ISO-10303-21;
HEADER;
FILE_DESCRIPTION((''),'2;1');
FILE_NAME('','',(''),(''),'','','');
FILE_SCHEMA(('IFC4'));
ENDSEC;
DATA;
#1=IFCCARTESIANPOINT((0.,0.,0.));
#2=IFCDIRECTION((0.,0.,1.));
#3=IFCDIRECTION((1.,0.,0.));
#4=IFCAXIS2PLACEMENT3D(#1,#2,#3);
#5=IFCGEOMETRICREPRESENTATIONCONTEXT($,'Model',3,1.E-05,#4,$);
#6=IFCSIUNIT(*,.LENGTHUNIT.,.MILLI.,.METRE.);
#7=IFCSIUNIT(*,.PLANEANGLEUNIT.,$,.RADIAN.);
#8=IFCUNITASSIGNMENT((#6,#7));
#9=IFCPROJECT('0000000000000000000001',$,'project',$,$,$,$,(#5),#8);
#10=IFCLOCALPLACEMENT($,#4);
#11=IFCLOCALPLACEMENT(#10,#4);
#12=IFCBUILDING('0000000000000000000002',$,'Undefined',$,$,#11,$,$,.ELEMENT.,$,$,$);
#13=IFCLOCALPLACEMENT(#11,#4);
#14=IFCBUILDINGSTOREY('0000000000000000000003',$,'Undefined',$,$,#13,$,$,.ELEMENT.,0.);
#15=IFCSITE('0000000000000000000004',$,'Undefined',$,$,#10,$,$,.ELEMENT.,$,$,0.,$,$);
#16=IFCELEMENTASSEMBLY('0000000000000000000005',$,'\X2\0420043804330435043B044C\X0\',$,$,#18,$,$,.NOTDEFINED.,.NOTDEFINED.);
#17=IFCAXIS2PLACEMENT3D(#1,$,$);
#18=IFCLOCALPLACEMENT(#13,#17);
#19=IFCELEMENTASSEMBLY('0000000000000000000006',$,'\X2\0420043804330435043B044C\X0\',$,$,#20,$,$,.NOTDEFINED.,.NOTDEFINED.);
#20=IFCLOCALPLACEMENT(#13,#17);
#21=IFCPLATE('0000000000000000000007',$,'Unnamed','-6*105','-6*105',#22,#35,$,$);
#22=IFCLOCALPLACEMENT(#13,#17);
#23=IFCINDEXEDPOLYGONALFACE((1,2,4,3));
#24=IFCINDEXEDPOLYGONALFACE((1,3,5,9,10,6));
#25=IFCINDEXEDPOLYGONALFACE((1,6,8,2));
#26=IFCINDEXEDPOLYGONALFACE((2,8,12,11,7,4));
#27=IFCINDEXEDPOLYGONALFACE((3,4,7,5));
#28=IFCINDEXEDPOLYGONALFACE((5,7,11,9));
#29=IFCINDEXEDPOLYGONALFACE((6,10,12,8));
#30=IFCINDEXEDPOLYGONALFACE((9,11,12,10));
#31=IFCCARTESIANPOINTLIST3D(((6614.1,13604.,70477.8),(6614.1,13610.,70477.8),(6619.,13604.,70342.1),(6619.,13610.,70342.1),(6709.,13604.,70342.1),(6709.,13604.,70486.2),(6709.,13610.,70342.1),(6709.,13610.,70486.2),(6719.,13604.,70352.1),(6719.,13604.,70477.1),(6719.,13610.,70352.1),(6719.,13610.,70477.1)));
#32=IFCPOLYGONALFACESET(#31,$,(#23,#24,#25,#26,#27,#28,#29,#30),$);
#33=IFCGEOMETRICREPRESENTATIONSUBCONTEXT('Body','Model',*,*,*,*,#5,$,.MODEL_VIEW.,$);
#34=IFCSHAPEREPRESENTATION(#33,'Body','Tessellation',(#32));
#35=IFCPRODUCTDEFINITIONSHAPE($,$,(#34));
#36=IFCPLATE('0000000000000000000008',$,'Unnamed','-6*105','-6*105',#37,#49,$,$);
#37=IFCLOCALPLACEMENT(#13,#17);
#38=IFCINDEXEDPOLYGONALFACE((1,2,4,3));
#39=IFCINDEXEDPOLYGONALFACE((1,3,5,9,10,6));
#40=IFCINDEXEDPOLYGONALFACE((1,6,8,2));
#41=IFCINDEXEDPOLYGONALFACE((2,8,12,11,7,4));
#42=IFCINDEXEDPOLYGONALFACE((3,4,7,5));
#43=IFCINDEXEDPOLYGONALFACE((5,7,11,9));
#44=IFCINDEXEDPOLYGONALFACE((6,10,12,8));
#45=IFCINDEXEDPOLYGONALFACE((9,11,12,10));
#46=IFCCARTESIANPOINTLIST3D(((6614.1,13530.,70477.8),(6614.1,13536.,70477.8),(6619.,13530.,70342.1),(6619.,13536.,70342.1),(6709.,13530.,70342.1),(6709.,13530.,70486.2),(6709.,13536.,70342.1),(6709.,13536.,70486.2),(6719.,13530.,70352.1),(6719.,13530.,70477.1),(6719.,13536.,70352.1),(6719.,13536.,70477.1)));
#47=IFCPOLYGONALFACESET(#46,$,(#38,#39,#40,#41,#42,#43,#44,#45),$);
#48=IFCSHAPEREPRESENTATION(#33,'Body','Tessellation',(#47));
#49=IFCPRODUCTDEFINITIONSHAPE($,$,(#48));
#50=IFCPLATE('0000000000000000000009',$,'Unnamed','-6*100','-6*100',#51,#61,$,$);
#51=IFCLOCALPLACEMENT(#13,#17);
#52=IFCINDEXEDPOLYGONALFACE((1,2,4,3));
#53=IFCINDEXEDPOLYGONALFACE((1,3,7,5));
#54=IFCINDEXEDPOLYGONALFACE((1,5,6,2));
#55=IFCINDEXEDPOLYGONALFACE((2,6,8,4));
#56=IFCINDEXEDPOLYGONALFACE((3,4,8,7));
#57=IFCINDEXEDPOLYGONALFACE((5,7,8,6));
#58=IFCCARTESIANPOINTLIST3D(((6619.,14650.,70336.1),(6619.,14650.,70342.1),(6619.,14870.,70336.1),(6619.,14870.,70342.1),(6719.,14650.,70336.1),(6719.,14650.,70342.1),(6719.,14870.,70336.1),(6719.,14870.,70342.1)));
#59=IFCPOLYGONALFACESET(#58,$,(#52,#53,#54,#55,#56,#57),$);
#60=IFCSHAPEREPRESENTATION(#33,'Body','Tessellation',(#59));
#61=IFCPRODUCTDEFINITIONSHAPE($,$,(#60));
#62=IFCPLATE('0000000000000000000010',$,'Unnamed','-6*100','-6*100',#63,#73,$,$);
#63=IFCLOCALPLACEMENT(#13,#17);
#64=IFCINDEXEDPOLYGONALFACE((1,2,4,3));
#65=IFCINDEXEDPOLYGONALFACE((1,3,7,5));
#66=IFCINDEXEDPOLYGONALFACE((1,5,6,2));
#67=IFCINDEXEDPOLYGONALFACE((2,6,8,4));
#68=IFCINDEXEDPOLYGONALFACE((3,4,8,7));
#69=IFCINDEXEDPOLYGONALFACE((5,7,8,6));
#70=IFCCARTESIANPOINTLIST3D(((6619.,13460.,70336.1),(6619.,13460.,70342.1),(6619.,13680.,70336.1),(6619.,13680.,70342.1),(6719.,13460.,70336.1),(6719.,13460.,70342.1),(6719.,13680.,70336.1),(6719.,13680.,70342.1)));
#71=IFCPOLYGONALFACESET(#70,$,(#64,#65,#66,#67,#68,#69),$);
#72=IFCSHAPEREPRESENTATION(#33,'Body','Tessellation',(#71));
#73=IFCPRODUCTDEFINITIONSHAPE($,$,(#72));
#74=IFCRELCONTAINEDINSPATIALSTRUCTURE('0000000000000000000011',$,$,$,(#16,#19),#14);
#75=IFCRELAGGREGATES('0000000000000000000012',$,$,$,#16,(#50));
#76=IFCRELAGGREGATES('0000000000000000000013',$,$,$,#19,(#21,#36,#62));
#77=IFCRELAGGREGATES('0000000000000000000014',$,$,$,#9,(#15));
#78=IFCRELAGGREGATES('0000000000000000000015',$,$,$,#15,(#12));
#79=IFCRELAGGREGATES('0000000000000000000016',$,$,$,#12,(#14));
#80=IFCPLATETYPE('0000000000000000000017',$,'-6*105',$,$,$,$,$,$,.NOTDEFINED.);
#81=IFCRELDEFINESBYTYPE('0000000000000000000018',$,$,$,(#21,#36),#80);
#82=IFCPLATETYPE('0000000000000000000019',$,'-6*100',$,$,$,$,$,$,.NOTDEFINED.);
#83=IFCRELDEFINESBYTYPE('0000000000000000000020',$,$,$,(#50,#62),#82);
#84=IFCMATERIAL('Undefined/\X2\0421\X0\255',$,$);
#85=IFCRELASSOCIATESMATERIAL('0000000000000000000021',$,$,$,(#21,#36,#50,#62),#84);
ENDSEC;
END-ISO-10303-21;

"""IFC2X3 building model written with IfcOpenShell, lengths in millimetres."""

from ifc_helpers import new_model, si_unit, frame, origin_with_axes, place, context, subcontext, project, spatial, polyline, outline, extrude, material, type_object, element, aggregate, save


model = new_model("IFC2X3")

# Units and contexts
model_context = context("Model", 3, precision=1e-05, world=origin_with_axes())
body_context = subcontext(model_context, "Body", "Model", "MODEL_VIEW")
ifc_project = project(units=[si_unit("LENGTHUNIT", "METRE", prefix="MILLI"), si_unit("PLANEANGLEUNIT", "RADIAN")], contexts=[model_context])

# Site, building, storey
site_placement = place(None, origin_with_axes())
site = spatial("IfcSite", under=ifc_project, at=site_placement, Name="Undefined", CompositionType="ELEMENT", RefElevation=0.0)
building_placement = place(site_placement, origin_with_axes())
building = spatial("IfcBuilding", under=site, at=building_placement, Name="Undefined", CompositionType="ELEMENT")
storey_placement = place(building_placement, origin_with_axes())
storey = spatial("IfcBuildingStorey", under=building, at=storey_placement, Name="Undefined", CompositionType="ELEMENT", Elevation=0.0)

# Element assemblies
assembly_1_placement = place(storey_placement, origin_with_axes())
assembly_1 = element("IfcElementAssembly", 1, at=assembly_1_placement, inside=storey, Name="Ригель", AssemblyPlace="NOTDEFINED", PredefinedType="NOTDEFINED")
ifc_material_1 = material(Name="Undefined/С255")
assembly_2_placement = place(storey_placement, origin_with_axes())
assembly_2 = element("IfcElementAssembly", 2, at=assembly_2_placement, inside=storey, Name="Ригель", AssemblyPlace="NOTDEFINED", PredefinedType="NOTDEFINED")

# Plates
plate_type_1 = type_object("IfcPlateType", Name="-6*105", PredefinedType="NOTDEFINED")
plate_1_placement = place(assembly_2_placement, frame((6719.0, 13607.0, 70342.1), z_axis=(0.0, -1.0, 0.0), x_axis=(0.0, 0.0, 1.0)))
plate_1 = element("IfcPlate", 3, at=plate_1_placement, type_object=plate_type_1, material=ifc_material_1, Name="Unnamed", Description="-6*105", ObjectType="-6*105", context=body_context, shape_type="SweptSolid", body=[
    extrude(outline(polyline([(0.0, 10.0), (10.0, 0.0), (135.0, 0.0), (144.1, 10.0), (135.7, 104.9), (0.0, 100.0), (0.0, 10.0)])), frame((0.0, 0.0, -3.0), z_axis=(0.0, 0.0, 1.0), x_axis=(1.0, 0.0, 0.0)), (0.0, 0.0, 1.0), 6.0),
])
plate_2_placement = place(assembly_2_placement, frame((6719.0, 13533.0, 70342.1), z_axis=(0.0, -1.0, 0.0), x_axis=(0.0, 0.0, 1.0)))
plate_2 = element("IfcPlate", 4, at=plate_2_placement, type_object=plate_type_1, material=ifc_material_1, Name="Unnamed", Description="-6*105", ObjectType="-6*105", context=body_context, shape_type="SweptSolid", body=[
    extrude(outline(polyline([(0.0, 10.0), (10.0, 0.0), (135.0, 0.0), (144.1, 10.0), (135.7, 104.9), (0.0, 100.0), (0.0, 10.0)])), frame((0.0, 0.0, -3.0), z_axis=(0.0, 0.0, 1.0), x_axis=(1.0, 0.0, 0.0)), (0.0, 0.0, 1.0), 6.0),
])
plate_type_2 = type_object("IfcPlateType", Name="-6*100", PredefinedType="NOTDEFINED")
plate_3_placement = place(assembly_1_placement, frame((6719.0, 14870.0, 70339.1), z_axis=(0.0, 0.0, 1.0), x_axis=(-1.0, 0.0, 0.0)))
plate_3 = element("IfcPlate", 5, at=plate_3_placement, type_object=plate_type_2, material=ifc_material_1, Name="Unnamed", Description="-6*100", ObjectType="-6*100", context=body_context, shape_type="SweptSolid", body=[
    extrude(outline(polyline([(0.0, 0.0), (100.0, 0.0), (100.0, 220.0), (0.0, 220.0), (0.0, 0.0)])), frame((0.0, 0.0, -3.0), z_axis=(0.0, 0.0, 1.0), x_axis=(1.0, 0.0, 0.0)), (0.0, 0.0, 1.0), 6.0),
])
plate_4_placement = place(assembly_2_placement, frame((6719.0, 13680.0, 70339.1), z_axis=(0.0, 0.0, 1.0), x_axis=(-1.0, 0.0, 0.0)))
plate_4 = element("IfcPlate", 6, at=plate_4_placement, type_object=plate_type_2, material=ifc_material_1, Name="Unnamed", Description="-6*100", ObjectType="-6*100", context=body_context, shape_type="SweptSolid", body=[
    extrude(outline(polyline([(0.0, 0.0), (100.0, 0.0), (100.0, 220.0), (0.0, 220.0), (0.0, 0.0)])), frame((0.0, 0.0, -3.0), z_axis=(0.0, 0.0, 1.0), x_axis=(1.0, 0.0, 0.0)), (0.0, 0.0, 1.0), 6.0),
])

aggregate(assembly_1, [plate_3])
aggregate(assembly_2, [plate_1, plate_2, plate_4])

save(model, "model.ifc")
